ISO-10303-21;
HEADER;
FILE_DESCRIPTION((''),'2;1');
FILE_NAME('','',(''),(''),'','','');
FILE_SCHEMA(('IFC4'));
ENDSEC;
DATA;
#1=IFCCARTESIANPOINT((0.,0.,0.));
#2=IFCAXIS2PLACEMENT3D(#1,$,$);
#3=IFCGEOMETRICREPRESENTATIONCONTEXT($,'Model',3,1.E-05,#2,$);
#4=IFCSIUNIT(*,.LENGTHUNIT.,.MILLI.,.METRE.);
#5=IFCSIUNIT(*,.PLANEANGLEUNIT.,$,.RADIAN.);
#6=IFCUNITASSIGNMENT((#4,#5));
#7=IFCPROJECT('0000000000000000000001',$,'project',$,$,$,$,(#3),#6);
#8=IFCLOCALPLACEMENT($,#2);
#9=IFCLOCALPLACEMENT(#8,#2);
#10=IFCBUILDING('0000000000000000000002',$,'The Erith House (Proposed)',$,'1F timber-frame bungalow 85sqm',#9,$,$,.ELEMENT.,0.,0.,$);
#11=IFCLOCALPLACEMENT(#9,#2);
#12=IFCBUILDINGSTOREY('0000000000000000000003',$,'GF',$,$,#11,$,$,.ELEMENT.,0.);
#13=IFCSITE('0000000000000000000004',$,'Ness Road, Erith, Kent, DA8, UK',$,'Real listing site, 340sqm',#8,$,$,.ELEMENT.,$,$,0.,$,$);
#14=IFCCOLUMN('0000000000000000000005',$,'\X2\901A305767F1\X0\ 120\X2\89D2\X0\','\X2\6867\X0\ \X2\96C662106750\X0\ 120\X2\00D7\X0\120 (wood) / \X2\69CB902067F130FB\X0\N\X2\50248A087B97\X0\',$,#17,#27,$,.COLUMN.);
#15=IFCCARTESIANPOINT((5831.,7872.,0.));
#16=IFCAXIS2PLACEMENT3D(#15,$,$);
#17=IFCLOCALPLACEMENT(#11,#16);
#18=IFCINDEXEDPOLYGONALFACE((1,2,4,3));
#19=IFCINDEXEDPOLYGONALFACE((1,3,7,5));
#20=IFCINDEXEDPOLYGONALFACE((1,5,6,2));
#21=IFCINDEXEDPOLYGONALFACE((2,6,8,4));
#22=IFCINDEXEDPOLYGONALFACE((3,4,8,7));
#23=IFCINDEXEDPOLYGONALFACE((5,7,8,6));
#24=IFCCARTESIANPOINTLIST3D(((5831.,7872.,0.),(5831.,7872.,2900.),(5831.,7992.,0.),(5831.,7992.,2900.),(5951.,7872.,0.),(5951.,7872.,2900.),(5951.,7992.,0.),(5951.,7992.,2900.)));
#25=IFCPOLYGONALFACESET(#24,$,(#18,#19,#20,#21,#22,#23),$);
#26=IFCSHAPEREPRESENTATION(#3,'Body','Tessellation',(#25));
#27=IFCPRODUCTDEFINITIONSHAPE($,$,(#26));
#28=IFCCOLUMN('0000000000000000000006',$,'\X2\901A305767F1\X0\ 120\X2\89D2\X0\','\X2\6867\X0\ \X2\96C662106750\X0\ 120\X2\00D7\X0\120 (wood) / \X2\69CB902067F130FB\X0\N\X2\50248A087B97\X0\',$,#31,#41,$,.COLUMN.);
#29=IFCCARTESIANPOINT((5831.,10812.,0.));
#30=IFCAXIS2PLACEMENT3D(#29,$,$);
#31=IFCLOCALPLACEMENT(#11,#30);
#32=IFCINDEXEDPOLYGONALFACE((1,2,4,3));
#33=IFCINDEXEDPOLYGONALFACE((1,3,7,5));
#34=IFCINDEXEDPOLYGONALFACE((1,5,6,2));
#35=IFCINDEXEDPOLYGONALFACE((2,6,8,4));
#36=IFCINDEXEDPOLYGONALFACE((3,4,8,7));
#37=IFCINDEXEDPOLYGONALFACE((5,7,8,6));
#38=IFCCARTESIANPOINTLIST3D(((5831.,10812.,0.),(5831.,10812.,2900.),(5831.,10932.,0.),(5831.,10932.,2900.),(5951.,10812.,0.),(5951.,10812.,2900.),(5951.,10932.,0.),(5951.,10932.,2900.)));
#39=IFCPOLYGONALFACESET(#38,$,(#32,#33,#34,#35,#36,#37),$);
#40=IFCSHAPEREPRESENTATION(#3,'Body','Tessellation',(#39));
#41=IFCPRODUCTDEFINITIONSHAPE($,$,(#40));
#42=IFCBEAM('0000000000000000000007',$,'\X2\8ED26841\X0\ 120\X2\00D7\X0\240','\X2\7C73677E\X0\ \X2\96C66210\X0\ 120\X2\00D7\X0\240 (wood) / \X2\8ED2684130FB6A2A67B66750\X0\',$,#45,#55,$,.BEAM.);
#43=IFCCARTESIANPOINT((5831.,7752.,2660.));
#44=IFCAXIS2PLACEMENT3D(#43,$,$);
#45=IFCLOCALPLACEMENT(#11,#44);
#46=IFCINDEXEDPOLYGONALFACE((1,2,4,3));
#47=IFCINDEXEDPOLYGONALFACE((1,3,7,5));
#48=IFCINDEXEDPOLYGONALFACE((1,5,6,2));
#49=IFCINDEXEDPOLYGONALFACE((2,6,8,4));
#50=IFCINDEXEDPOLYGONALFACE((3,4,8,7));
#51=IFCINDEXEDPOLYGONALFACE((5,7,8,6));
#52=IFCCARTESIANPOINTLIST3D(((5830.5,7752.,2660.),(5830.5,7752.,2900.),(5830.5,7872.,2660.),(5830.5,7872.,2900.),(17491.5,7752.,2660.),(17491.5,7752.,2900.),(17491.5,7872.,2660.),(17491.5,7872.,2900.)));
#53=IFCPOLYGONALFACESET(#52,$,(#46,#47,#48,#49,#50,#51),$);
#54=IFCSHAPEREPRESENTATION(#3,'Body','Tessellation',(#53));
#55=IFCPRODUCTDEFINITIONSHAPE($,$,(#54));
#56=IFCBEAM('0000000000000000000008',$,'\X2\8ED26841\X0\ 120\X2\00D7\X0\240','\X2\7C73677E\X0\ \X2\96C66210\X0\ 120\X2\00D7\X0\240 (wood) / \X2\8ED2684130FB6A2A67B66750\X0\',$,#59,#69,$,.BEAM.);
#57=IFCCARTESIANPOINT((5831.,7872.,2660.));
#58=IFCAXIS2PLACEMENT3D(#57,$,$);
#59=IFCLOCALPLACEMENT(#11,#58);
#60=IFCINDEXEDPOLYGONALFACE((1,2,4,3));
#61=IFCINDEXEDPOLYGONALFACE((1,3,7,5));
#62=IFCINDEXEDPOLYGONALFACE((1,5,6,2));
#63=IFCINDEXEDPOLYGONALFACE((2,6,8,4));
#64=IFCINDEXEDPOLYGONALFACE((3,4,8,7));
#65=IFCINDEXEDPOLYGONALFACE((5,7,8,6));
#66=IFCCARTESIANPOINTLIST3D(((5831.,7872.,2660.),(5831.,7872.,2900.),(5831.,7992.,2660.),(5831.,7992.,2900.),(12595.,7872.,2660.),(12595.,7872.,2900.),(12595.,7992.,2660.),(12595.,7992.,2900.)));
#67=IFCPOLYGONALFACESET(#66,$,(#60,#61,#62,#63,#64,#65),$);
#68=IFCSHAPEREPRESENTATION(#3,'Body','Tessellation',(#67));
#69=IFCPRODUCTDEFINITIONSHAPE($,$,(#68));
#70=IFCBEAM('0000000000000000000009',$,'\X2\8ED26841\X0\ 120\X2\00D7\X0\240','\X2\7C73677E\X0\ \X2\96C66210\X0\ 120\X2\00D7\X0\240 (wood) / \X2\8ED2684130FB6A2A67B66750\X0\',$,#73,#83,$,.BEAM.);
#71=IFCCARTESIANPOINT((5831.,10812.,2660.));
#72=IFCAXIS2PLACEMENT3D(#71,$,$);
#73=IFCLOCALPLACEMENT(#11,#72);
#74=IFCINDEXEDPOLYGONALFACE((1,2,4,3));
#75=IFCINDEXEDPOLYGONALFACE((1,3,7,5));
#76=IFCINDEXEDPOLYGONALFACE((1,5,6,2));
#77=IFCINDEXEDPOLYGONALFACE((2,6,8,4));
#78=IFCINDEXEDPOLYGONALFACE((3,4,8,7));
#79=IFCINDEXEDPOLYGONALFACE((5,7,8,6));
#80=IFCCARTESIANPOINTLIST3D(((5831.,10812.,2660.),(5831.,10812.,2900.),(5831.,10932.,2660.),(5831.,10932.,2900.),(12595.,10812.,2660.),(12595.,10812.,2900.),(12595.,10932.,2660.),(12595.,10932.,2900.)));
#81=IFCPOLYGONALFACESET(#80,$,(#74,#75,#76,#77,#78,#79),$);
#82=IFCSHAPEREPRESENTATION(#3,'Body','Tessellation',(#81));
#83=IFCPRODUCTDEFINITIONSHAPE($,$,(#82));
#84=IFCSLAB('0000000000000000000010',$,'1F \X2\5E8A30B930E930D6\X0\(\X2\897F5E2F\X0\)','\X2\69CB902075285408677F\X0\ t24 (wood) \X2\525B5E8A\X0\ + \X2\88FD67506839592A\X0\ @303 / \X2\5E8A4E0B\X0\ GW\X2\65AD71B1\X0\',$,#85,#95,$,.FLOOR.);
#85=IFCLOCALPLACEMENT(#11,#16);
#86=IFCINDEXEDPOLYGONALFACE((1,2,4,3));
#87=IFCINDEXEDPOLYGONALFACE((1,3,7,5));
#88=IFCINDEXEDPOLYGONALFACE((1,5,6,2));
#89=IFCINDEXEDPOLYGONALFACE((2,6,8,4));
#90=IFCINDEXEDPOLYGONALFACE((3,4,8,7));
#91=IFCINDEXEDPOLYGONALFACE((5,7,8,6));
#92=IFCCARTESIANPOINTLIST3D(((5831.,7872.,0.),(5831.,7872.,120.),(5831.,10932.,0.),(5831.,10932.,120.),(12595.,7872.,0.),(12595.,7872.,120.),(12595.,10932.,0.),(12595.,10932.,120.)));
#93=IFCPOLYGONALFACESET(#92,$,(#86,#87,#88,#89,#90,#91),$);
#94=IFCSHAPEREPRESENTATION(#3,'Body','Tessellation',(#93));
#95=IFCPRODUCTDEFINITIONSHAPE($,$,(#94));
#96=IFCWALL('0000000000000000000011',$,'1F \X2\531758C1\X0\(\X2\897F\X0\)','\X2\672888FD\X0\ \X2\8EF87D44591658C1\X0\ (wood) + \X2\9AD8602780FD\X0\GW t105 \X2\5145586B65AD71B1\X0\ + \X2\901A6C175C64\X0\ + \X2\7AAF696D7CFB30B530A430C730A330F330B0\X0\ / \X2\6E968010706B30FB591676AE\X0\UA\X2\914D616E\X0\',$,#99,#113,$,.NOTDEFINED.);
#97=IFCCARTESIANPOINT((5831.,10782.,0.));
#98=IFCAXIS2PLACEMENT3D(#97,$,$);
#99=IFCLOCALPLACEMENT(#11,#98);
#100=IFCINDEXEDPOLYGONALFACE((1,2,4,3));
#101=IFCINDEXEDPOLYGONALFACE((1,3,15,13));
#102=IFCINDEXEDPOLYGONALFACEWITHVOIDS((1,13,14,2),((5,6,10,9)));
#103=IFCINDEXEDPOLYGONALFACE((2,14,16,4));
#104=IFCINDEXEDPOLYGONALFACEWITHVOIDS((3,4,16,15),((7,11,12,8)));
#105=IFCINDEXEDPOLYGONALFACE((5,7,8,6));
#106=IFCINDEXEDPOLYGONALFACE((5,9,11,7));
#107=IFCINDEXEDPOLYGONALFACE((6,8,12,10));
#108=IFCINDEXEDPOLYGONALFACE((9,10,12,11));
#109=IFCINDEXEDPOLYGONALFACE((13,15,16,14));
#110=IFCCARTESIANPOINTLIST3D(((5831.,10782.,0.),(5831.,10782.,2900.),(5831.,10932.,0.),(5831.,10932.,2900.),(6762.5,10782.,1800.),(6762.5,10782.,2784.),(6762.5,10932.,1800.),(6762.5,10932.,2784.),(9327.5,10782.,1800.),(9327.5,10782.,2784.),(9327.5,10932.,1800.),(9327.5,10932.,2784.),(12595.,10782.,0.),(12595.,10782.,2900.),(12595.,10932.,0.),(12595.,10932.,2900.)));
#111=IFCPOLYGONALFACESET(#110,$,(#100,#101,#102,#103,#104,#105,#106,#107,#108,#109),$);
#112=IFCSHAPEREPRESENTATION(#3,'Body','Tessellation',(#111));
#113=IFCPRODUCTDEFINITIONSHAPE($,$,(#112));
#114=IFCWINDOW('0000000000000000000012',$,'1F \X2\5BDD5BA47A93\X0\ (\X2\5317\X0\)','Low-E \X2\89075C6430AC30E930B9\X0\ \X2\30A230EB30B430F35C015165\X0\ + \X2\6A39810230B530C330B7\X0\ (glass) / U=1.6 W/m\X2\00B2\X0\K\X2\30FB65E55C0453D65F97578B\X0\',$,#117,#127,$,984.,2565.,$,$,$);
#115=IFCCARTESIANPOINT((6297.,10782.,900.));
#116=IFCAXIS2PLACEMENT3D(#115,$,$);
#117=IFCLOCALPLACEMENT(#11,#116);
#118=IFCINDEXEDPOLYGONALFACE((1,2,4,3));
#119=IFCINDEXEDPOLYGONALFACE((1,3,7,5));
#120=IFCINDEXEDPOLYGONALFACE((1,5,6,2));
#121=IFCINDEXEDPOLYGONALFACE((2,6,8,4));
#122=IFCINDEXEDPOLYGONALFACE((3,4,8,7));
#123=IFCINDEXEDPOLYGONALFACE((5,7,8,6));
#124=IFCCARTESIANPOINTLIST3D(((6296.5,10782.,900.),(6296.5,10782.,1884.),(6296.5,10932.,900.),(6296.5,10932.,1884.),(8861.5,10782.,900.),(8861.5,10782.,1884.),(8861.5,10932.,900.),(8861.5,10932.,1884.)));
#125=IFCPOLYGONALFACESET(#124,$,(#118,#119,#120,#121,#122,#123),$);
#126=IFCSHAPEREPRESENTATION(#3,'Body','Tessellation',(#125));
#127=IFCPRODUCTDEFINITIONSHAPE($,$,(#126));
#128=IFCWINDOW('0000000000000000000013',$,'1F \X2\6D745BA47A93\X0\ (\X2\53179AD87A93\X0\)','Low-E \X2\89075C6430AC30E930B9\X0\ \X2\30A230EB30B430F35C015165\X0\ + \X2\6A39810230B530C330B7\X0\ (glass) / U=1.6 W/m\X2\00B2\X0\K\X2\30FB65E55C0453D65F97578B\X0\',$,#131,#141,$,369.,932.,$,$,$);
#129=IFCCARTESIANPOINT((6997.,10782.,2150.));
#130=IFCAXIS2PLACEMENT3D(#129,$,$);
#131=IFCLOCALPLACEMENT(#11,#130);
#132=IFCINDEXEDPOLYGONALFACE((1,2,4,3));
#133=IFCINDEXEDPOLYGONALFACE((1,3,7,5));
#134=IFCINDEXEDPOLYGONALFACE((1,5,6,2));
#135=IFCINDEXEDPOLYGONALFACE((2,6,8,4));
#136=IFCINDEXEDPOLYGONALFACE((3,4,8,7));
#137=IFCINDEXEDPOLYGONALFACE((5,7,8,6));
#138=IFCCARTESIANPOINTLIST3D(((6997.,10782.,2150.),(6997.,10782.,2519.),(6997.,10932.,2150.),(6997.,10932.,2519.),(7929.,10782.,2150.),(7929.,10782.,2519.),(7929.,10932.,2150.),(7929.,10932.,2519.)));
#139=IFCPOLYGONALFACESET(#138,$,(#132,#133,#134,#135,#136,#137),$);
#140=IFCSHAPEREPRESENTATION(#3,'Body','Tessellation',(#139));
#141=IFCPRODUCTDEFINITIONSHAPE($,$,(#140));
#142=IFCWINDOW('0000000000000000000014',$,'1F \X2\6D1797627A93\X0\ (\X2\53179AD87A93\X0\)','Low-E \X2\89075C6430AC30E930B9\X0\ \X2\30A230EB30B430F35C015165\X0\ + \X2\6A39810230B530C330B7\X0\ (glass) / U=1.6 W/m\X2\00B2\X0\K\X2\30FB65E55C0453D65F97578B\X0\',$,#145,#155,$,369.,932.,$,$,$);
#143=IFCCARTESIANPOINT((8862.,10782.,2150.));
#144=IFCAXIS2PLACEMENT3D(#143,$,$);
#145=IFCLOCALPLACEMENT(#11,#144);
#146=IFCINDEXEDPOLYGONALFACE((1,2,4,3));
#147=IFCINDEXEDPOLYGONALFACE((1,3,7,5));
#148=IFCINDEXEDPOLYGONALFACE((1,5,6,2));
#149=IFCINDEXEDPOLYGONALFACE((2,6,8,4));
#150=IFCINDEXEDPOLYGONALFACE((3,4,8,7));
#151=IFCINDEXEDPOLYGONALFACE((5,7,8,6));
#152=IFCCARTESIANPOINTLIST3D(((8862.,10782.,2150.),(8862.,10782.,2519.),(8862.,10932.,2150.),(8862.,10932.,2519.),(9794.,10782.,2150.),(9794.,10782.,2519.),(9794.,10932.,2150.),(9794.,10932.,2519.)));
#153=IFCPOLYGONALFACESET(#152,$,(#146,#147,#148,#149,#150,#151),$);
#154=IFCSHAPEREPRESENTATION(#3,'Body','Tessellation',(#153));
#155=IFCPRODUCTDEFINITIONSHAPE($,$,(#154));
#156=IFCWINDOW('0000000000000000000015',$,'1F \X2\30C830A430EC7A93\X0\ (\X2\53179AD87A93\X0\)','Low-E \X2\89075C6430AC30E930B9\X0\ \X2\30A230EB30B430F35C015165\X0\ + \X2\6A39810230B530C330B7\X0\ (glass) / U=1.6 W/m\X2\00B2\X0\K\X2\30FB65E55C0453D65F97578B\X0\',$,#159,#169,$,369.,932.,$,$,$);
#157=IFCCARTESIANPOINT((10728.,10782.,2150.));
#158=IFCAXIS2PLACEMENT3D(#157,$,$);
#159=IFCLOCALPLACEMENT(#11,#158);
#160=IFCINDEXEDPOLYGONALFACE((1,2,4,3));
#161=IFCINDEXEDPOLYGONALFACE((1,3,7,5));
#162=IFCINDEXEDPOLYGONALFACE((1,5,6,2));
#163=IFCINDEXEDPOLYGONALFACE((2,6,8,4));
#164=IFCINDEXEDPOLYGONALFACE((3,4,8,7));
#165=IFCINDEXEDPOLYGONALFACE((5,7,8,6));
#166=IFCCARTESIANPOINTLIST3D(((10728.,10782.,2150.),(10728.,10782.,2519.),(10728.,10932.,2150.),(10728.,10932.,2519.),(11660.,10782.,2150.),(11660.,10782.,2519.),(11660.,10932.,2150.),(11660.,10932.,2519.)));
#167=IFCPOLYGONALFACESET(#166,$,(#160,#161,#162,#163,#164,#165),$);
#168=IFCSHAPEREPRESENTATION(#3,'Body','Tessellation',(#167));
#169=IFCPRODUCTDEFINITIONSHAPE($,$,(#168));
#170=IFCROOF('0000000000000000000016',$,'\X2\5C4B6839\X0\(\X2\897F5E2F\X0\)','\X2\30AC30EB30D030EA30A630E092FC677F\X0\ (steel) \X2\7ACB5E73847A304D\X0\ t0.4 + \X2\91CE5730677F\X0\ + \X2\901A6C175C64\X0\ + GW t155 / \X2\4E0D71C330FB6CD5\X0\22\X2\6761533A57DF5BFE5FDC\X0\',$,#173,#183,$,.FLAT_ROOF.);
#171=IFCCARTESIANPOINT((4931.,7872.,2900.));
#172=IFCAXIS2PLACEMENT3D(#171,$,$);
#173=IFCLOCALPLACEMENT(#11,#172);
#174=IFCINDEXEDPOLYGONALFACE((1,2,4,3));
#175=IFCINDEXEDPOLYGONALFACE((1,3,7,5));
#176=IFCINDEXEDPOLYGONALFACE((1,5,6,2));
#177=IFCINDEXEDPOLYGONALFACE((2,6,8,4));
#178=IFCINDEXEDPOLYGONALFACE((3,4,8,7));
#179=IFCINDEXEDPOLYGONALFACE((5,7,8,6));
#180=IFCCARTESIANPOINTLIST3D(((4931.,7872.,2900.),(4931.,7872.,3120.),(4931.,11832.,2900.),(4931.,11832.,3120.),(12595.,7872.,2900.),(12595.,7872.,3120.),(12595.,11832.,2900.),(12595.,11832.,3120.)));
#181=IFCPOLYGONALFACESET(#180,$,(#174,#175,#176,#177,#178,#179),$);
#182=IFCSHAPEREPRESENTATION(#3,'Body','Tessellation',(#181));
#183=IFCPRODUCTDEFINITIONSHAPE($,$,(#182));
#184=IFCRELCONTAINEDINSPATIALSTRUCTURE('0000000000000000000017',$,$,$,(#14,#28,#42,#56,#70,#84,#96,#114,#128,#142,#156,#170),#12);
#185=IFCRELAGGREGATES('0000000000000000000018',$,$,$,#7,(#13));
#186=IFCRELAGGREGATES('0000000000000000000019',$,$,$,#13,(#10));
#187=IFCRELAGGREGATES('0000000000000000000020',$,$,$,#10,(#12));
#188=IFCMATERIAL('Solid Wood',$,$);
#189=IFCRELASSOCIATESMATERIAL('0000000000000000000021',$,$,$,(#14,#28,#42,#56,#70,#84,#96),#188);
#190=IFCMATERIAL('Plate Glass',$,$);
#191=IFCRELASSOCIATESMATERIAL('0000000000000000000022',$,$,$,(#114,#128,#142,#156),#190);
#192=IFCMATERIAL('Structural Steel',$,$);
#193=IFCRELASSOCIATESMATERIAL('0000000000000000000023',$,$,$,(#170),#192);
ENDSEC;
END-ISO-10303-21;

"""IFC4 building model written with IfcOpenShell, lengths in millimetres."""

from ifc_helpers import new_model, si_unit, frame, frame_2d, origin, place, context, project, spatial, rectangle, extrude, material, element, fill, save


model = new_model("IFC4")

# Units and contexts
model_context = context("Model", 3, precision=1e-05, world=origin())
ifc_project = project(units=[si_unit("LENGTHUNIT", "METRE", prefix="MILLI"), si_unit("PLANEANGLEUNIT", "RADIAN")], contexts=[model_context])

# Site, building, storey
site_placement = place(None, origin())
site = spatial("IfcSite", under=ifc_project, at=site_placement, Name="Ness Road, Erith, Kent, DA8, UK", ObjectType="Real listing site, 340sqm", CompositionType="ELEMENT", RefElevation=0.0)
building_placement = place(site_placement, origin())
building = spatial("IfcBuilding", under=site, at=building_placement, Name="The Erith House (Proposed)", ObjectType="1F timber-frame bungalow 85sqm", CompositionType="ELEMENT", ElevationOfRefHeight=0.0, ElevationOfTerrain=0.0)
storey_placement = place(building_placement, origin())
storey = spatial("IfcBuildingStorey", under=building, at=storey_placement, Name="GF", CompositionType="ELEMENT", Elevation=0.0)

# Columns
ifc_material_1 = material(Name="Solid Wood")
column_1_placement = place(storey_placement, frame((5831.0, 7872.0, 0.0)))
element("IfcColumn", 1, at=column_1_placement, inside=storey, material=ifc_material_1, Name="通し柱 120角", Description="桧 集成材 120×120 (wood) / 構造柱・N値計算", PredefinedType="COLUMN", context=model_context, shape_type="SweptSolid", body=[
    extrude(rectangle(XDim=120.0, YDim=120.0, at=frame_2d((60.0, 60.0))), frame((5831.0, 7872.0, 0.0)), (0.0, 0.0, 1.0), 2900.0),
])
column_2_placement = place(storey_placement, frame((5831.0, 10812.0, 0.0)))
element("IfcColumn", 2, at=column_2_placement, inside=storey, material=ifc_material_1, Name="通し柱 120角", Description="桧 集成材 120×120 (wood) / 構造柱・N値計算", PredefinedType="COLUMN", context=model_context, shape_type="SweptSolid", body=[
    extrude(rectangle(XDim=120.0, YDim=120.0, at=frame_2d((60.0, 60.0))), frame((5831.0, 10812.0, 0.0)), (0.0, 0.0, 1.0), 2900.0),
])

# Beams
beam_1_placement = place(storey_placement, frame((5831.0, 7752.0, 2660.0)))
element("IfcBeam", 3, at=beam_1_placement, inside=storey, material=ifc_material_1, Name="軒桁 120×240", Description="米松 集成 120×240 (wood) / 軒桁・横架材", PredefinedType="BEAM", context=model_context, shape_type="SweptSolid", body=[
    extrude(rectangle(XDim=11661.0, YDim=120.0, at=frame_2d((5830.0, 60.0))), frame((5831.0, 7752.0, 2660.0)), (0.0, 0.0, 1.0), 240.0),
])
beam_2_placement = place(storey_placement, frame((5831.0, 7872.0, 2660.0)))
element("IfcBeam", 4, at=beam_2_placement, inside=storey, material=ifc_material_1, Name="軒桁 120×240", Description="米松 集成 120×240 (wood) / 軒桁・横架材", PredefinedType="BEAM", context=model_context, shape_type="SweptSolid", body=[
    extrude(rectangle(XDim=6764.0, YDim=120.0, at=frame_2d((3382.0, 60.0))), frame((5831.0, 7872.0, 2660.0)), (0.0, 0.0, 1.0), 240.0),
])
beam_3_placement = place(storey_placement, frame((5831.0, 10812.0, 2660.0)))
element("IfcBeam", 5, at=beam_3_placement, inside=storey, material=ifc_material_1, Name="軒桁 120×240", Description="米松 集成 120×240 (wood) / 軒桁・横架材", PredefinedType="BEAM", context=model_context, shape_type="SweptSolid", body=[
    extrude(rectangle(XDim=6764.0, YDim=120.0, at=frame_2d((3382.0, 60.0))), frame((5831.0, 10812.0, 2660.0)), (0.0, 0.0, 1.0), 240.0),
])

# Slab
slab_placement = place(storey_placement, frame((5831.0, 7872.0, 0.0)))
element("IfcSlab", 6, at=slab_placement, inside=storey, material=ifc_material_1, Name="1F 床スラブ(西帯)", Description="構造用合板 t24 (wood) 剛床 + 製材根太 @303 / 床下 GW断熱", PredefinedType="FLOOR", context=model_context, shape_type="SweptSolid", body=[
    extrude(rectangle(XDim=6764.0, YDim=3060.0, at=frame_2d((3382.0, 1530.0))), frame((5831.0, 7872.0, 0.0)), (0.0, 0.0, 1.0), 120.0),
])

# Wall, openings, windows
wall_1_placement = place(storey_placement, frame((5831.0, 10782.0, 0.0)))
wall_1 = element("IfcWall", 7, at=wall_1_placement, inside=storey, material=ifc_material_1, Name="1F 北壁(西)", Description="木製 軸組外壁 (wood) + 高性能GW t105 充填断熱 + 通気層 + 窯業系サイディング / 準耐火・外皮UA配慮", PredefinedType="NOTDEFINED", context=model_context, shape_type="SweptSolid", body=[
    extrude(rectangle(XDim=6764.0, YDim=150.0, at=frame_2d((3382.0, 75.0))), frame((5831.0, 10782.0, 0.0)), (0.0, 0.0, 1.0), 2900.0),
])
opening_1_placement = place(storey_placement, frame((6297.0, 10782.0, 900.0)))
opening_1 = element("IfcOpeningElement", 8, at=opening_1_placement, cuts=wall_1, PredefinedType="NOTDEFINED", context=model_context, shape_type="SweptSolid", body=[
    extrude(rectangle(XDim=2565.0, YDim=150.0, at=frame_2d((1282.0, 75.0))), frame((6297.0, 10782.0, 900.0)), (0.0, 0.0, 1.0), 984.0),
])
opening_2_placement = place(storey_placement, frame((6997.0, 10782.0, 2150.0)))
opening_2 = element("IfcOpeningElement", 9, at=opening_2_placement, cuts=wall_1, PredefinedType="NOTDEFINED", context=model_context, shape_type="SweptSolid", body=[
    extrude(rectangle(XDim=932.0, YDim=150.0, at=frame_2d((466.0, 75.0))), frame((6997.0, 10782.0, 2150.0)), (0.0, 0.0, 1.0), 369.0),
])
opening_3_placement = place(storey_placement, frame((8862.0, 10782.0, 2150.0)))
opening_3 = element("IfcOpeningElement", 10, at=opening_3_placement, cuts=wall_1, PredefinedType="NOTDEFINED", context=model_context, shape_type="SweptSolid", body=[
    extrude(rectangle(XDim=932.0, YDim=150.0, at=frame_2d((466.0, 75.0))), frame((8862.0, 10782.0, 2150.0)), (0.0, 0.0, 1.0), 369.0),
])
opening_4_placement = place(storey_placement, frame((10728.0, 10782.0, 2150.0)))
opening_4 = element("IfcOpeningElement", 11, at=opening_4_placement, cuts=wall_1, PredefinedType="NOTDEFINED", context=model_context, shape_type="SweptSolid", body=[
    extrude(rectangle(XDim=932.0, YDim=150.0, at=frame_2d((466.0, 75.0))), frame((10728.0, 10782.0, 2150.0)), (0.0, 0.0, 1.0), 369.0),
])
ifc_material_2 = material(Name="Plate Glass")
window_1_placement = place(storey_placement, frame((6297.0, 10782.0, 900.0)))
window_1 = element("IfcWindow", 12, at=window_1_placement, inside=storey, material=ifc_material_2, Name="1F 寝室窓 (北)", Description="Low-E 複層ガラス アルゴン封入 + 樹脂サッシ (glass) / U=1.6 W/m²K・日射取得型", OverallHeight=984.0, OverallWidth=2565.0, context=model_context, shape_type="SweptSolid", body=[
    extrude(rectangle(XDim=2565.0, YDim=150.0, at=frame_2d((1282.0, 75.0))), frame((6297.0, 10782.0, 900.0)), (0.0, 0.0, 1.0), 984.0),
])
fill(opening_1, window_1)
window_2_placement = place(storey_placement, frame((6997.0, 10782.0, 2150.0)))
window_2 = element("IfcWindow", 13, at=window_2_placement, inside=storey, material=ifc_material_2, Name="1F 浴室窓 (北高窓)", Description="Low-E 複層ガラス アルゴン封入 + 樹脂サッシ (glass) / U=1.6 W/m²K・日射取得型", OverallHeight=369.0, OverallWidth=932.0, context=model_context, shape_type="SweptSolid", body=[
    extrude(rectangle(XDim=932.0, YDim=150.0, at=frame_2d((466.0, 75.0))), frame((6997.0, 10782.0, 2150.0)), (0.0, 0.0, 1.0), 369.0),
])
fill(opening_2, window_2)
window_3_placement = place(storey_placement, frame((8862.0, 10782.0, 2150.0)))
window_3 = element("IfcWindow", 14, at=window_3_placement, inside=storey, material=ifc_material_2, Name="1F 洗面窓 (北高窓)", Description="Low-E 複層ガラス アルゴン封入 + 樹脂サッシ (glass) / U=1.6 W/m²K・日射取得型", OverallHeight=369.0, OverallWidth=932.0, context=model_context, shape_type="SweptSolid", body=[
    extrude(rectangle(XDim=932.0, YDim=150.0, at=frame_2d((466.0, 75.0))), frame((8862.0, 10782.0, 2150.0)), (0.0, 0.0, 1.0), 369.0),
])
fill(opening_3, window_3)
window_4_placement = place(storey_placement, frame((10728.0, 10782.0, 2150.0)))
window_4 = element("IfcWindow", 15, at=window_4_placement, inside=storey, material=ifc_material_2, Name="1F トイレ窓 (北高窓)", Description="Low-E 複層ガラス アルゴン封入 + 樹脂サッシ (glass) / U=1.6 W/m²K・日射取得型", OverallHeight=369.0, OverallWidth=932.0, context=model_context, shape_type="SweptSolid", body=[
    extrude(rectangle(XDim=932.0, YDim=150.0, at=frame_2d((466.0, 75.0))), frame((10728.0, 10782.0, 2150.0)), (0.0, 0.0, 1.0), 369.0),
])
fill(opening_4, window_4)

# Roof
ifc_material_3 = material(Name="Structural Steel")
roof_placement = place(storey_placement, frame((4931.0, 7872.0, 2900.0)))
element("IfcRoof", 16, at=roof_placement, inside=storey, material=ifc_material_3, Name="屋根(西帯)", Description="ガルバリウム鋼板 (steel) 立平葺き t0.4 + 野地板 + 通気層 + GW t155 / 不燃・法22条区域対応", PredefinedType="FLAT_ROOF", context=model_context, shape_type="SweptSolid", body=[
    extrude(rectangle(XDim=7664.0, YDim=3960.0, at=frame_2d((3832.0, 1980.0))), frame((4931.0, 7872.0, 2900.0)), (0.0, 0.0, 1.0), 220.0),
])

save(model, "model.ifc")
